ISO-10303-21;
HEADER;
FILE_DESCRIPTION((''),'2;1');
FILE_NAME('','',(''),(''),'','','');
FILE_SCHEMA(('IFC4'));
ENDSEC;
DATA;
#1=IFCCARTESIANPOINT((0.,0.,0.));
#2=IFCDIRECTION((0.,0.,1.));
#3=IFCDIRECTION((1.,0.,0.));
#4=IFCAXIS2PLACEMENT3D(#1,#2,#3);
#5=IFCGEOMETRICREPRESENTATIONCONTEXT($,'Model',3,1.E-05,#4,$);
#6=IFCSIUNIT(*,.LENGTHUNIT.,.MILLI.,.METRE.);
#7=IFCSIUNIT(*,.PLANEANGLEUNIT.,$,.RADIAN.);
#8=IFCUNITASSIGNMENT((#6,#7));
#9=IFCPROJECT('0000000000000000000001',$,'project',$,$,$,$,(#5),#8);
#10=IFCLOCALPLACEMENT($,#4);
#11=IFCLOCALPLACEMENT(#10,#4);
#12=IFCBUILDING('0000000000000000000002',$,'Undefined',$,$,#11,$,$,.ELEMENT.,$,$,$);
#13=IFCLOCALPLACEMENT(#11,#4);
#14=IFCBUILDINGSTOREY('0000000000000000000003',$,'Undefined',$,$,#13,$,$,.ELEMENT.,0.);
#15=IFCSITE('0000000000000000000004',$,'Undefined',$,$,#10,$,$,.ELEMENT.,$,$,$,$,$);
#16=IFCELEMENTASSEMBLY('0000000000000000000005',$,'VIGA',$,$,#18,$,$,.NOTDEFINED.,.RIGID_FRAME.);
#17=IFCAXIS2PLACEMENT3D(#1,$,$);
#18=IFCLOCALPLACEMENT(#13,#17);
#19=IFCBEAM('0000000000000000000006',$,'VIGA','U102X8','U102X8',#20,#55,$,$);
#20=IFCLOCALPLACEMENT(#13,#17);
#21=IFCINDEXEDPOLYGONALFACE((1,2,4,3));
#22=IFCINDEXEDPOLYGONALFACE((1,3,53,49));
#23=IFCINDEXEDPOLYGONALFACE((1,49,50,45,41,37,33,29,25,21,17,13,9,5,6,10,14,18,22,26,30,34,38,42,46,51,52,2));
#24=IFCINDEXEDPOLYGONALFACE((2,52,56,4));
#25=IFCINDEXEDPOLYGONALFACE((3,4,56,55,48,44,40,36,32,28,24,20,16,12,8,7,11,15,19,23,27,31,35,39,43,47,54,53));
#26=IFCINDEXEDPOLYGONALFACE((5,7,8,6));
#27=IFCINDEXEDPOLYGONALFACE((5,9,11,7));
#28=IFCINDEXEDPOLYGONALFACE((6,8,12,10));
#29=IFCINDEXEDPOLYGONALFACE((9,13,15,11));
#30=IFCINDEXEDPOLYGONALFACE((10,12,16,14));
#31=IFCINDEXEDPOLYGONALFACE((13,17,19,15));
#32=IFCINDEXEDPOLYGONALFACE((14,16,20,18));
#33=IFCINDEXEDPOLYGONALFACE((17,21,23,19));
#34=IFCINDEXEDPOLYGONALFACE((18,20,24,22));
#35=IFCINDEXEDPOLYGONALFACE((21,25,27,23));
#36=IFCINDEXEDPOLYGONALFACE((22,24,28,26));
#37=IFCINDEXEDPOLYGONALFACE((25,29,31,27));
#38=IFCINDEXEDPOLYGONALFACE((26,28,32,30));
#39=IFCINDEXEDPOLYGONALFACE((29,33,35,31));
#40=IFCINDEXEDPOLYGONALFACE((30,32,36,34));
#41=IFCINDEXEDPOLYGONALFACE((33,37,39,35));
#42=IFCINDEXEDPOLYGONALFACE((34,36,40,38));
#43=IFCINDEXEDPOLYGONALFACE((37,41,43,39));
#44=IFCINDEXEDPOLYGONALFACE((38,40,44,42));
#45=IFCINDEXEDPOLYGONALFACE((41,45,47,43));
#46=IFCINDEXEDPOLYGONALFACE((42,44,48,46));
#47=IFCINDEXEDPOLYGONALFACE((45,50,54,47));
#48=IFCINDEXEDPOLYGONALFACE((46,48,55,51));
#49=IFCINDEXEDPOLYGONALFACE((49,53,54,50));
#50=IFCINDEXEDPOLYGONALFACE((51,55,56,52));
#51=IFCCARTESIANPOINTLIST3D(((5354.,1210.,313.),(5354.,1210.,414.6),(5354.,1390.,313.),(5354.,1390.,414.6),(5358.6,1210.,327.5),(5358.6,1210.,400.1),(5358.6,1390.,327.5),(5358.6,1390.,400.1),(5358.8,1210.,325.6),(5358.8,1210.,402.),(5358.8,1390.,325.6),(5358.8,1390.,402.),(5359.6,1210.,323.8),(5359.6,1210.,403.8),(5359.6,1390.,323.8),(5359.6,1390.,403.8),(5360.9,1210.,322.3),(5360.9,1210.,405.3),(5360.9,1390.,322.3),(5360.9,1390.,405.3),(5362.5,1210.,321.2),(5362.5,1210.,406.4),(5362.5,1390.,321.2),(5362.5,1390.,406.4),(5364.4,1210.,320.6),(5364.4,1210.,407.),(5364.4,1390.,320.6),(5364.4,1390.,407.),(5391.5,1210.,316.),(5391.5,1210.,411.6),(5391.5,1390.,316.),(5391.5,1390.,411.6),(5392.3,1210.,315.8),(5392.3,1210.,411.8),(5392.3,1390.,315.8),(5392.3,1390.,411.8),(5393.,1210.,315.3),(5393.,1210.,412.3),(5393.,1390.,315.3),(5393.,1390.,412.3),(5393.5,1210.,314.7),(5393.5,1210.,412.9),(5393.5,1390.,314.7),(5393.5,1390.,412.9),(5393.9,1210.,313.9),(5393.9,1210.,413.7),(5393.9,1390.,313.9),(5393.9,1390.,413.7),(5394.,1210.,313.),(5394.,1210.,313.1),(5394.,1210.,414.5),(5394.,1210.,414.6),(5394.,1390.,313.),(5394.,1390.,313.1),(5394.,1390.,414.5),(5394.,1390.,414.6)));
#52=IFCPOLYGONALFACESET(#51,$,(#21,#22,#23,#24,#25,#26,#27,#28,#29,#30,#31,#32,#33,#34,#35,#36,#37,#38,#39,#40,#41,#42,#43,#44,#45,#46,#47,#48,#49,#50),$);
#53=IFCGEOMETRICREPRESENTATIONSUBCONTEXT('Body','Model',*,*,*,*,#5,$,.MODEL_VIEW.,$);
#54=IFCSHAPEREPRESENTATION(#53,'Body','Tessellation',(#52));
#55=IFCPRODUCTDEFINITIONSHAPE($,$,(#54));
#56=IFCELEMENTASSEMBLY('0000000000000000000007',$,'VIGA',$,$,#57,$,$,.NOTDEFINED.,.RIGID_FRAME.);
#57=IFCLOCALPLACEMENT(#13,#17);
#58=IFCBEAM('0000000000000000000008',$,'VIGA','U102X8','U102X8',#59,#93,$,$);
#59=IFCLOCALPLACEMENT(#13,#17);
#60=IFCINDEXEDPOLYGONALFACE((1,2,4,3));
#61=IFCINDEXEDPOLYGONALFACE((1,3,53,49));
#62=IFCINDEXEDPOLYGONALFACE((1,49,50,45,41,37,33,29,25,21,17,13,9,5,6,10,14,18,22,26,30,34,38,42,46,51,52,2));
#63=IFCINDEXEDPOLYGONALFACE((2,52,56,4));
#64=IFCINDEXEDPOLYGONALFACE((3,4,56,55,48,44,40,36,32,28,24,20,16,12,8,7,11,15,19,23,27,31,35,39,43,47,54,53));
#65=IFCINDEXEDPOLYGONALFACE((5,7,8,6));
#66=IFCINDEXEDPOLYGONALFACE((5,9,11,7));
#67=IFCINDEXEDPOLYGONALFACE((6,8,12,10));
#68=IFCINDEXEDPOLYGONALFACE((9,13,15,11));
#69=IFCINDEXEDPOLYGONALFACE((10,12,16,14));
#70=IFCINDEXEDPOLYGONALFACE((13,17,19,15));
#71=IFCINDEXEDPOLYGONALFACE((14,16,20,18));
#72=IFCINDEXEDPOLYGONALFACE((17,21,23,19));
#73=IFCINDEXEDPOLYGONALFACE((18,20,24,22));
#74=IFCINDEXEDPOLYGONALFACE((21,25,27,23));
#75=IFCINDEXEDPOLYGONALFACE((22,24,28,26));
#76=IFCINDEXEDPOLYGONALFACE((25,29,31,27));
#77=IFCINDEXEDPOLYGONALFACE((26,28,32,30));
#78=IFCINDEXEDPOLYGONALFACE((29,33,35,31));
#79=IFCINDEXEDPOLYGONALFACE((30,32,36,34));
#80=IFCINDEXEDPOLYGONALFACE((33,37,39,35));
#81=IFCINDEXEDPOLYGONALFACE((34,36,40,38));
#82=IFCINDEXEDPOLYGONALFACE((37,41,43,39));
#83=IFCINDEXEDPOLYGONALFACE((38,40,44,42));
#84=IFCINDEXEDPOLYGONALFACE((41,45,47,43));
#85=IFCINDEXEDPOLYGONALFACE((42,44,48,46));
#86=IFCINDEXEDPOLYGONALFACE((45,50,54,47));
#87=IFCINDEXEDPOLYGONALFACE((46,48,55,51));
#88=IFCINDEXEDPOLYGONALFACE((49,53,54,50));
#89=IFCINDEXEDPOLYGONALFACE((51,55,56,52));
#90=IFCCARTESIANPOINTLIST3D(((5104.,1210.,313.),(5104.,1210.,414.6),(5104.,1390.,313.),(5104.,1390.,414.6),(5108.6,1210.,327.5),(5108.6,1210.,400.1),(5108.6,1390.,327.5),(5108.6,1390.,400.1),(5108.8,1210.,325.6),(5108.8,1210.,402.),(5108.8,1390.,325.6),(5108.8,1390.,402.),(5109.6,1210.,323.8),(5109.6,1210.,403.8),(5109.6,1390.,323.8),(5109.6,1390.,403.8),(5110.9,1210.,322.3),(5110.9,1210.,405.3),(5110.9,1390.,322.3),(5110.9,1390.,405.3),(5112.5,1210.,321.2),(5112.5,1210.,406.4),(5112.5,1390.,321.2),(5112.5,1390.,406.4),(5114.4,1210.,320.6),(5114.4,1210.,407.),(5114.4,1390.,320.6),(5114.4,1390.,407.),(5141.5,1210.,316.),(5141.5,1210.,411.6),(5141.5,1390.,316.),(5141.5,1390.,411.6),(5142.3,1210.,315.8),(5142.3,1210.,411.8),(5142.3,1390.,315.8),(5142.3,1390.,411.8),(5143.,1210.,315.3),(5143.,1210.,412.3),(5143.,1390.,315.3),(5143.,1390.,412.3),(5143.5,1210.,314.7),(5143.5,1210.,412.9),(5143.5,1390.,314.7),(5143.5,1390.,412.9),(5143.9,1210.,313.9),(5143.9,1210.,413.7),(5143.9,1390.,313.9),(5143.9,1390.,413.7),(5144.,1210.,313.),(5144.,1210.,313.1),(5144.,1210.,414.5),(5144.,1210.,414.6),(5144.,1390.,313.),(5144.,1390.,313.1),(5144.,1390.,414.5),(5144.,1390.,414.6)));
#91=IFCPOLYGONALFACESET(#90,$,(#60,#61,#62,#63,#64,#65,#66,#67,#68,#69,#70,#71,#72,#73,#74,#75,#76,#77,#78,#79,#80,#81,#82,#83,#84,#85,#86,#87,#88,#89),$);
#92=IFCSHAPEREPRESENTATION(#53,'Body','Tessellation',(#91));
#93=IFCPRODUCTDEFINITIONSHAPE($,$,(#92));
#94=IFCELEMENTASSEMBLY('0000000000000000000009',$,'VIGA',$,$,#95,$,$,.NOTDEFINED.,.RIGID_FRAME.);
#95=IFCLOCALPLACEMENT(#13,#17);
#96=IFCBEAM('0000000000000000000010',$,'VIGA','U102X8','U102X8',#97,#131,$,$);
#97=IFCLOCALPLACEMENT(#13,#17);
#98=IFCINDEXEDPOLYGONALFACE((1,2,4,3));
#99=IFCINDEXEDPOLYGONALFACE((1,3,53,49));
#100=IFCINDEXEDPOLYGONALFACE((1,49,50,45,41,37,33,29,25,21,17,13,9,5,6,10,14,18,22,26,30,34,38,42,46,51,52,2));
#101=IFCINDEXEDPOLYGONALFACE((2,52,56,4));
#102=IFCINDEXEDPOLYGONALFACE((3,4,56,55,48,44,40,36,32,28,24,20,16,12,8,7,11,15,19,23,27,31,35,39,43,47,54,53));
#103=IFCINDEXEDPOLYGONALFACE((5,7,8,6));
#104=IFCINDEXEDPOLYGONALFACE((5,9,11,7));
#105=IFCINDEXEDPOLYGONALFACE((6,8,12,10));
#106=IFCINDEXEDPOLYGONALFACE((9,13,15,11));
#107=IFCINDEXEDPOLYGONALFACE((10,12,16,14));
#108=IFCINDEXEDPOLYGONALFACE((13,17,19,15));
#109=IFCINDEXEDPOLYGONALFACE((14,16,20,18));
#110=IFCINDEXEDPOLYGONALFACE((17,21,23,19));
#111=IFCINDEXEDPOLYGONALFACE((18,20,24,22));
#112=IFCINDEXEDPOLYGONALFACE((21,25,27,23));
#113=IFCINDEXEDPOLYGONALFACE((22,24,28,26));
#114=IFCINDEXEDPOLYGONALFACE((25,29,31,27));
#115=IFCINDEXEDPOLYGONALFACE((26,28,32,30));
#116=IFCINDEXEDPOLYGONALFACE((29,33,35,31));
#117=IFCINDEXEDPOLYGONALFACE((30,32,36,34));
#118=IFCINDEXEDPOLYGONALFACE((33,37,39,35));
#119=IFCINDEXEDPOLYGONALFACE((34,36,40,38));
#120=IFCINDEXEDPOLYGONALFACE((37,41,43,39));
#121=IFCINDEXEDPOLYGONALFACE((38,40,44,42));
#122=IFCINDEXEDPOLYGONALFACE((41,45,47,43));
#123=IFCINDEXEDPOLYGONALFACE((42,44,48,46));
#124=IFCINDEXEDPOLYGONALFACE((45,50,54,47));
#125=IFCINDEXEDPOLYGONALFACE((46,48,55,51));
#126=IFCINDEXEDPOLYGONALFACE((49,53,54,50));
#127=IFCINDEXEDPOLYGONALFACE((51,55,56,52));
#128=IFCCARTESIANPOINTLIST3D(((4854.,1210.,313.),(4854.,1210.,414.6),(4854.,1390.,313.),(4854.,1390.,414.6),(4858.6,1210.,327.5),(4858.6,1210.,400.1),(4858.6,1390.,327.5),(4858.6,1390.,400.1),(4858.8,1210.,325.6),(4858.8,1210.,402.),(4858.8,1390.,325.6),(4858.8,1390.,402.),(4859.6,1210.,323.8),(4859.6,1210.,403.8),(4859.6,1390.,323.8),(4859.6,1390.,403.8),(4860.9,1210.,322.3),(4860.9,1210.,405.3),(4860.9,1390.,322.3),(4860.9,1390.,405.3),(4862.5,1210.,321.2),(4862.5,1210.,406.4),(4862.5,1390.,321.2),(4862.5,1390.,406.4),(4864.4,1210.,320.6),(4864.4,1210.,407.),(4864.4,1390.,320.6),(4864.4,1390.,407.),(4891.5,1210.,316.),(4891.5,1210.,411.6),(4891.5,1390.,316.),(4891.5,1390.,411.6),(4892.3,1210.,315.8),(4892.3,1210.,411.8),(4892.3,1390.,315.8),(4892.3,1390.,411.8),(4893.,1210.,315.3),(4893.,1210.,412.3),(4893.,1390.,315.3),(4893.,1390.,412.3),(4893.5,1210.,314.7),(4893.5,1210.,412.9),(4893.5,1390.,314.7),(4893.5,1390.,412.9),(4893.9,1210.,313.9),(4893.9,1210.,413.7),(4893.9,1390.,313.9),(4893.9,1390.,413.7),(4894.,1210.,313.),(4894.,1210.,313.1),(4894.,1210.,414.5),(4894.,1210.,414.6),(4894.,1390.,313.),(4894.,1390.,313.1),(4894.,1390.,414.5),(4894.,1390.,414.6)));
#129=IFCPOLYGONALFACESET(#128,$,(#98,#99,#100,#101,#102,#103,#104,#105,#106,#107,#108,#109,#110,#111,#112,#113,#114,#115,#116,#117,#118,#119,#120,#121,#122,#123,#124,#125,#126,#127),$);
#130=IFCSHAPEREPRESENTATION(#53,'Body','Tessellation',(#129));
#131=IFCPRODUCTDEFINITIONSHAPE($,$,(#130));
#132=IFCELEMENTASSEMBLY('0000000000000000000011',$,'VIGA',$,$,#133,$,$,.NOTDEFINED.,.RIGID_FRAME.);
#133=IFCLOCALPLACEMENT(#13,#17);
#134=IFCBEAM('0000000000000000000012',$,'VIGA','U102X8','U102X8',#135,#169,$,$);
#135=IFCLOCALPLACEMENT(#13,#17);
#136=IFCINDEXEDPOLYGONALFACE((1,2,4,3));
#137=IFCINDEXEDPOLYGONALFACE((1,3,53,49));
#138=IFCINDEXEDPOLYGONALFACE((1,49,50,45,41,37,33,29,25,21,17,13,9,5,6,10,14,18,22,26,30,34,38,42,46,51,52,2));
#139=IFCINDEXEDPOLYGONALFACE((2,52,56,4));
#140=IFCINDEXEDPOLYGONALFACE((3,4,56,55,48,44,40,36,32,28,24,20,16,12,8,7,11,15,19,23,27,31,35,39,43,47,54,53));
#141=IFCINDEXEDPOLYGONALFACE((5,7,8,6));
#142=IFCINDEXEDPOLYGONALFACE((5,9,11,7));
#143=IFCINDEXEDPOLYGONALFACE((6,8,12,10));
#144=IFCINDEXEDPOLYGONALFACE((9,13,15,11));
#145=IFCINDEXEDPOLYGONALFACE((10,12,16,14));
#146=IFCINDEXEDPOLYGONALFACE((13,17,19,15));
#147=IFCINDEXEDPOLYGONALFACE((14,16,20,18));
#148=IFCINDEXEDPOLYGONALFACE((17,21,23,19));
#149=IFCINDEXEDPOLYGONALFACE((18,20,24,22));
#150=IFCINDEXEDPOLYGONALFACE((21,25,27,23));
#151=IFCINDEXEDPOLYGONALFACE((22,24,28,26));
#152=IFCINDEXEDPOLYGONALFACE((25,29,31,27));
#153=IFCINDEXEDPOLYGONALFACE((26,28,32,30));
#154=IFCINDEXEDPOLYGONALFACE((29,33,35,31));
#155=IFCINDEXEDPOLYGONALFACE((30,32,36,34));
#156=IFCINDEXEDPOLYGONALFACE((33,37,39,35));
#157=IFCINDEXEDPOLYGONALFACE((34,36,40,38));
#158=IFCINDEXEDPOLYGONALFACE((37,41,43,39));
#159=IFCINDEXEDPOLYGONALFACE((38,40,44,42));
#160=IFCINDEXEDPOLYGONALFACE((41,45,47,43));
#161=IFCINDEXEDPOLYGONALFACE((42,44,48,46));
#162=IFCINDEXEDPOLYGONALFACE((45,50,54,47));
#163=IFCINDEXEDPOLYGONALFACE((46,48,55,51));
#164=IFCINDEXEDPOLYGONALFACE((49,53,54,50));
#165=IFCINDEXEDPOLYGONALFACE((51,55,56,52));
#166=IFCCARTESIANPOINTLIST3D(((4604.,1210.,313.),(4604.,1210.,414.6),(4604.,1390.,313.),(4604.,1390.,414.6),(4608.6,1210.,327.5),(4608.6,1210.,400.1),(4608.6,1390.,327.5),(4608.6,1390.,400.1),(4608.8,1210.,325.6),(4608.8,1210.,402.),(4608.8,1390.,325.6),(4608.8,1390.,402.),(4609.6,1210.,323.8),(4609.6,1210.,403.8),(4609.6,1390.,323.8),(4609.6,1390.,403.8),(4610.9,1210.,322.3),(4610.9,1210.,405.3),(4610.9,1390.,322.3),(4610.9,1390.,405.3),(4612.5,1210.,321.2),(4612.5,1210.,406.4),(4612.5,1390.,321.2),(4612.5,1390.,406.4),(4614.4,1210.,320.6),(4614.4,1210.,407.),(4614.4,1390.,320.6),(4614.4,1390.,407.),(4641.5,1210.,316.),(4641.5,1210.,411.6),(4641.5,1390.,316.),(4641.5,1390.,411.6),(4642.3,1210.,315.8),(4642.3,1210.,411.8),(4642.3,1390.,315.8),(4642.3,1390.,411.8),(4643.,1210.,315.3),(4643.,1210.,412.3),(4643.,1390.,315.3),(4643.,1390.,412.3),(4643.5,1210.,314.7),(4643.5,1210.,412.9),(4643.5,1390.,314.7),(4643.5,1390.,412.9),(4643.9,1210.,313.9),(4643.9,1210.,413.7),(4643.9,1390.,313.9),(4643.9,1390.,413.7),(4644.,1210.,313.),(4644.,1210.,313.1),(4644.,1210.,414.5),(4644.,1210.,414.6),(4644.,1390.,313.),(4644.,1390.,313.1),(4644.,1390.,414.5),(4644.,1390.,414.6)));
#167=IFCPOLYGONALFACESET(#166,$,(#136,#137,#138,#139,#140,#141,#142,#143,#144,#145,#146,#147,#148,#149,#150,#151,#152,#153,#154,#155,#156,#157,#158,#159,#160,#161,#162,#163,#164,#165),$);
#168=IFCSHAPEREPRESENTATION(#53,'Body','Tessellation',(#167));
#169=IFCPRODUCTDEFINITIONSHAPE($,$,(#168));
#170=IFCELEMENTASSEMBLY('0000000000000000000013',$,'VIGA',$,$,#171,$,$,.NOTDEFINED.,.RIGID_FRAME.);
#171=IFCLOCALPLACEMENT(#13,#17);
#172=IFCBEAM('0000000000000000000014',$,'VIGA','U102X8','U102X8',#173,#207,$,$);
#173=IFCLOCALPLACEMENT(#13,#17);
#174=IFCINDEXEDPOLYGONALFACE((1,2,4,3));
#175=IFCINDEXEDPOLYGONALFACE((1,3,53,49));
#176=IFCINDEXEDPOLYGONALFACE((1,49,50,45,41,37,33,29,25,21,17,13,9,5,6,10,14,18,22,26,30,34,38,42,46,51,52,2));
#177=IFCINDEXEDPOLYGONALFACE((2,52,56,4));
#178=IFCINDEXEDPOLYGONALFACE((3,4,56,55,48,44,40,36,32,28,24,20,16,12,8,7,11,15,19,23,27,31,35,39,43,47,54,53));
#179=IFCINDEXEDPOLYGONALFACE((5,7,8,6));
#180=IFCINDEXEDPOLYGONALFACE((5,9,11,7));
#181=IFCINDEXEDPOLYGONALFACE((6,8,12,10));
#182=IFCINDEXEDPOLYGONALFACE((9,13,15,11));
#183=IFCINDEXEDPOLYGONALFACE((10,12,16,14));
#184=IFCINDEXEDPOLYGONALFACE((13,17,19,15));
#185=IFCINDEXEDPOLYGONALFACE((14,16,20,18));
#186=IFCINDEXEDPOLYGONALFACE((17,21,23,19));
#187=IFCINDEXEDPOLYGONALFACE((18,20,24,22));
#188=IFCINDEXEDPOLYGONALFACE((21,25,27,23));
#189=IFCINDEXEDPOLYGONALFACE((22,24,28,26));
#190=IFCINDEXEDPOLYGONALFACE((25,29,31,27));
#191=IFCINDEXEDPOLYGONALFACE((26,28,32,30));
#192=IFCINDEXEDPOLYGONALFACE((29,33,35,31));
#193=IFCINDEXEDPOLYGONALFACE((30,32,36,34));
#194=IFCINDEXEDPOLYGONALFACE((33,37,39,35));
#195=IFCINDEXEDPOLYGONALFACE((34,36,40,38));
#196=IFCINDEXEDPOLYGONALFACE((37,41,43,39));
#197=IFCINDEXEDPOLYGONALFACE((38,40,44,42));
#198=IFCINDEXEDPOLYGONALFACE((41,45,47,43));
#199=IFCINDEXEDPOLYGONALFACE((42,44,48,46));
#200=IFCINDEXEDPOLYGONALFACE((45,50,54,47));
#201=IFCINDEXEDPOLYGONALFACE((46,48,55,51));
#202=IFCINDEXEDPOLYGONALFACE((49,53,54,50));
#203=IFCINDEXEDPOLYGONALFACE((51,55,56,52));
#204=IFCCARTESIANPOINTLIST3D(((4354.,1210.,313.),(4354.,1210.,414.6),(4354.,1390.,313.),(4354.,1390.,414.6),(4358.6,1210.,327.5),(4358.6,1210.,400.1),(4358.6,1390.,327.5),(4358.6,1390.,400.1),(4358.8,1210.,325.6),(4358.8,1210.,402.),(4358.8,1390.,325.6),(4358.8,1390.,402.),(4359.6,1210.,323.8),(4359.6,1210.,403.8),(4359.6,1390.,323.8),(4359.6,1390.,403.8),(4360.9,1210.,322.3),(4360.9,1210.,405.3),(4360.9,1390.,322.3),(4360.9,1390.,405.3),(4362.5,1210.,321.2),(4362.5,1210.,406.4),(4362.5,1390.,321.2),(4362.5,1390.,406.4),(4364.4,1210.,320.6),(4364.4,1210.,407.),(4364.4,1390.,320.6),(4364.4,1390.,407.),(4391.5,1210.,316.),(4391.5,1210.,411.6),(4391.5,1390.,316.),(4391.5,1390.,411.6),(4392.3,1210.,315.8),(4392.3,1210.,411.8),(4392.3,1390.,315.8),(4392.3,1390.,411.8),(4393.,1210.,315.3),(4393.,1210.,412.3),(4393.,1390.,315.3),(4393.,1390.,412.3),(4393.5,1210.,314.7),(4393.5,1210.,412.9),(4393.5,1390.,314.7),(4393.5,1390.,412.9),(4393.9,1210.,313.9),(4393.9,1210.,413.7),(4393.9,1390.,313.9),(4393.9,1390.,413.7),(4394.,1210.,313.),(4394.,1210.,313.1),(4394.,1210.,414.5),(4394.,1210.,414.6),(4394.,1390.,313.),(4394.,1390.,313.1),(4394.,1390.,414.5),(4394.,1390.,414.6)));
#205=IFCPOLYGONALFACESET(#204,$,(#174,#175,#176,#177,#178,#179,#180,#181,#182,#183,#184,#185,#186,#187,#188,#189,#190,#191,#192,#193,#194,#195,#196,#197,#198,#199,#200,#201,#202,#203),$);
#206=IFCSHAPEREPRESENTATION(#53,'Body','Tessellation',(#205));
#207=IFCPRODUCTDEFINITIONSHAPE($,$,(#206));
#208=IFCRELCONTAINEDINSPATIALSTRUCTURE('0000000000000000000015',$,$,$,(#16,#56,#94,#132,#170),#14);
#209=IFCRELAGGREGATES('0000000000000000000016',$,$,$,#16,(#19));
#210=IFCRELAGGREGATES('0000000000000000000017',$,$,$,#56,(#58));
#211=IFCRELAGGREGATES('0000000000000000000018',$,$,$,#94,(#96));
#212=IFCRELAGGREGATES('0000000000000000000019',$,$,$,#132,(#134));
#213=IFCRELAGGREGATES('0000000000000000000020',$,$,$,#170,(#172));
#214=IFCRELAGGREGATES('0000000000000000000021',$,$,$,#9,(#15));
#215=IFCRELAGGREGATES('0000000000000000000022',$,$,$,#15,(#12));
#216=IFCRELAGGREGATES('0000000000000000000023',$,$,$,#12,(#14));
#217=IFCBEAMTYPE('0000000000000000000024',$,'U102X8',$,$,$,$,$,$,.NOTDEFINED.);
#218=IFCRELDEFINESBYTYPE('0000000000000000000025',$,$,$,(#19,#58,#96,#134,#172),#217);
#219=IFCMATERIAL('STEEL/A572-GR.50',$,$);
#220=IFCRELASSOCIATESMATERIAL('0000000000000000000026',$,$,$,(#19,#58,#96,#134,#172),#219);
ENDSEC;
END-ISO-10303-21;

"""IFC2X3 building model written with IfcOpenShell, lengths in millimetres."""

from ifc_helpers import new_model, si_unit, frame, origin_with_axes, origin_2d_with_axis, place, context, subcontext, project, spatial, u_section, extrude, material, type_object, element, aggregate, save


model = new_model("IFC2X3")

# Units and contexts
model_context = context("Model", 3, precision=1e-05, world=origin_with_axes())
body_context = subcontext(model_context, "Body", "Model", "MODEL_VIEW")
ifc_project = project(units=[si_unit("LENGTHUNIT", "METRE", prefix="MILLI"), si_unit("PLANEANGLEUNIT", "RADIAN")], contexts=[model_context])

# Site, building, storey
site_placement = place(None, origin_with_axes())
site = spatial("IfcSite", under=ifc_project, at=site_placement, Name="Undefined", CompositionType="ELEMENT")
building_placement = place(site_placement, origin_with_axes())
building = spatial("IfcBuilding", under=site, at=building_placement, Name="Undefined", CompositionType="ELEMENT")
storey_placement = place(building_placement, origin_with_axes())
storey = spatial("IfcBuildingStorey", under=building, at=storey_placement, Name="Undefined", CompositionType="ELEMENT", Elevation=0.0)

# Element assemblies, beams
ifc_material = material(Name="STEEL/A572-GR.50")
beam_type = type_object("IfcBeamType", Name="U102X8", PredefinedType="NOTDEFINED")
assembly_1_placement = place(storey_placement, origin_with_axes())
assembly_1 = element("IfcElementAssembly", 1, at=assembly_1_placement, inside=storey, Name="VIGA", AssemblyPlace="NOTDEFINED", PredefinedType="RIGID_FRAME")
beam_1_placement = place(assembly_1_placement, frame((5374.0, 1210.0, 363.8), z_axis=(0.0, 0.0, 1.0), x_axis=(0.0, 1.0, 0.0)))
beam_1 = element("IfcBeam", 2, at=beam_1_placement, type_object=beam_type, material=ifc_material, Name="VIGA", Description="U102X8", ObjectType="U102X8", context=body_context, shape_type="SweptSolid", body=[
    extrude(u_section(Depth=101.6, FlangeWidth=40.0, WebThickness=4.6, FlangeThickness=6.0, FilletRadius=7.0, EdgeRadius=3.0, FlangeSlope=0.16839, at=origin_2d_with_axis()), frame((180.0, 0.0, 0.0), z_axis=(-1.0, 0.0, 0.0), x_axis=(0.0, -1.0, 0.0)), (0.0, 0.0, 1.0), 180.0),
])
aggregate(assembly_1, [beam_1])
assembly_2_placement = place(storey_placement, origin_with_axes())
assembly_2 = element("IfcElementAssembly", 3, at=assembly_2_placement, inside=storey, Name="VIGA", AssemblyPlace="NOTDEFINED", PredefinedType="RIGID_FRAME")
beam_2_placement = place(assembly_2_placement, frame((5124.0, 1210.0, 363.8), z_axis=(0.0, 0.0, 1.0), x_axis=(0.0, 1.0, 0.0)))
beam_2 = element("IfcBeam", 4, at=beam_2_placement, type_object=beam_type, material=ifc_material, Name="VIGA", Description="U102X8", ObjectType="U102X8", context=body_context, shape_type="SweptSolid", body=[
    extrude(u_section(Depth=101.6, FlangeWidth=40.0, WebThickness=4.6, FlangeThickness=6.0, FilletRadius=7.0, EdgeRadius=3.0, FlangeSlope=0.16839, at=origin_2d_with_axis()), frame((180.0, 0.0, 0.0), z_axis=(-1.0, 0.0, 0.0), x_axis=(0.0, -1.0, 0.0)), (0.0, 0.0, 1.0), 180.0),
])
aggregate(assembly_2, [beam_2])
assembly_3_placement = place(storey_placement, origin_with_axes())
assembly_3 = element("IfcElementAssembly", 5, at=assembly_3_placement, inside=storey, Name="VIGA", AssemblyPlace="NOTDEFINED", PredefinedType="RIGID_FRAME")
beam_3_placement = place(assembly_3_placement, frame((4874.0, 1210.0, 363.8), z_axis=(0.0, 0.0, 1.0), x_axis=(0.0, 1.0, 0.0)))
beam_3 = element("IfcBeam", 6, at=beam_3_placement, type_object=beam_type, material=ifc_material, Name="VIGA", Description="U102X8", ObjectType="U102X8", context=body_context, shape_type="SweptSolid", body=[
    extrude(u_section(Depth=101.6, FlangeWidth=40.0, WebThickness=4.6, FlangeThickness=6.0, FilletRadius=7.0, EdgeRadius=3.0, FlangeSlope=0.16839, at=origin_2d_with_axis()), frame((180.0, 0.0, 0.0), z_axis=(-1.0, 0.0, 0.0), x_axis=(0.0, -1.0, 0.0)), (0.0, 0.0, 1.0), 180.0),
])
aggregate(assembly_3, [beam_3])
assembly_4_placement = place(storey_placement, origin_with_axes())
assembly_4 = element("IfcElementAssembly", 7, at=assembly_4_placement, inside=storey, Name="VIGA", AssemblyPlace="NOTDEFINED", PredefinedType="RIGID_FRAME")
beam_4_placement = place(assembly_4_placement, frame((4624.0, 1210.0, 363.8), z_axis=(0.0, 0.0, 1.0), x_axis=(0.0, 1.0, 0.0)))
beam_4 = element("IfcBeam", 8, at=beam_4_placement, type_object=beam_type, material=ifc_material, Name="VIGA", Description="U102X8", ObjectType="U102X8", context=body_context, shape_type="SweptSolid", body=[
    extrude(u_section(Depth=101.6, FlangeWidth=40.0, WebThickness=4.6, FlangeThickness=6.0, FilletRadius=7.0, EdgeRadius=3.0, FlangeSlope=0.16839, at=origin_2d_with_axis()), frame((180.0, 0.0, 0.0), z_axis=(-1.0, 0.0, 0.0), x_axis=(0.0, -1.0, 0.0)), (0.0, 0.0, 1.0), 180.0),
])
aggregate(assembly_4, [beam_4])
assembly_5_placement = place(storey_placement, origin_with_axes())
assembly_5 = element("IfcElementAssembly", 9, at=assembly_5_placement, inside=storey, Name="VIGA", AssemblyPlace="NOTDEFINED", PredefinedType="RIGID_FRAME")
beam_5_placement = place(assembly_5_placement, frame((4374.0, 1210.0, 363.8), z_axis=(0.0, 0.0, 1.0), x_axis=(0.0, 1.0, 0.0)))
beam_5 = element("IfcBeam", 10, at=beam_5_placement, type_object=beam_type, material=ifc_material, Name="VIGA", Description="U102X8", ObjectType="U102X8", context=body_context, shape_type="SweptSolid", body=[
    extrude(u_section(Depth=101.6, FlangeWidth=40.0, WebThickness=4.6, FlangeThickness=6.0, FilletRadius=7.0, EdgeRadius=3.0, FlangeSlope=0.16839, at=origin_2d_with_axis()), frame((180.0, 0.0, 0.0), z_axis=(-1.0, 0.0, 0.0), x_axis=(0.0, -1.0, 0.0)), (0.0, 0.0, 1.0), 180.0),
])
aggregate(assembly_5, [beam_5])

save(model, "model.ifc")
